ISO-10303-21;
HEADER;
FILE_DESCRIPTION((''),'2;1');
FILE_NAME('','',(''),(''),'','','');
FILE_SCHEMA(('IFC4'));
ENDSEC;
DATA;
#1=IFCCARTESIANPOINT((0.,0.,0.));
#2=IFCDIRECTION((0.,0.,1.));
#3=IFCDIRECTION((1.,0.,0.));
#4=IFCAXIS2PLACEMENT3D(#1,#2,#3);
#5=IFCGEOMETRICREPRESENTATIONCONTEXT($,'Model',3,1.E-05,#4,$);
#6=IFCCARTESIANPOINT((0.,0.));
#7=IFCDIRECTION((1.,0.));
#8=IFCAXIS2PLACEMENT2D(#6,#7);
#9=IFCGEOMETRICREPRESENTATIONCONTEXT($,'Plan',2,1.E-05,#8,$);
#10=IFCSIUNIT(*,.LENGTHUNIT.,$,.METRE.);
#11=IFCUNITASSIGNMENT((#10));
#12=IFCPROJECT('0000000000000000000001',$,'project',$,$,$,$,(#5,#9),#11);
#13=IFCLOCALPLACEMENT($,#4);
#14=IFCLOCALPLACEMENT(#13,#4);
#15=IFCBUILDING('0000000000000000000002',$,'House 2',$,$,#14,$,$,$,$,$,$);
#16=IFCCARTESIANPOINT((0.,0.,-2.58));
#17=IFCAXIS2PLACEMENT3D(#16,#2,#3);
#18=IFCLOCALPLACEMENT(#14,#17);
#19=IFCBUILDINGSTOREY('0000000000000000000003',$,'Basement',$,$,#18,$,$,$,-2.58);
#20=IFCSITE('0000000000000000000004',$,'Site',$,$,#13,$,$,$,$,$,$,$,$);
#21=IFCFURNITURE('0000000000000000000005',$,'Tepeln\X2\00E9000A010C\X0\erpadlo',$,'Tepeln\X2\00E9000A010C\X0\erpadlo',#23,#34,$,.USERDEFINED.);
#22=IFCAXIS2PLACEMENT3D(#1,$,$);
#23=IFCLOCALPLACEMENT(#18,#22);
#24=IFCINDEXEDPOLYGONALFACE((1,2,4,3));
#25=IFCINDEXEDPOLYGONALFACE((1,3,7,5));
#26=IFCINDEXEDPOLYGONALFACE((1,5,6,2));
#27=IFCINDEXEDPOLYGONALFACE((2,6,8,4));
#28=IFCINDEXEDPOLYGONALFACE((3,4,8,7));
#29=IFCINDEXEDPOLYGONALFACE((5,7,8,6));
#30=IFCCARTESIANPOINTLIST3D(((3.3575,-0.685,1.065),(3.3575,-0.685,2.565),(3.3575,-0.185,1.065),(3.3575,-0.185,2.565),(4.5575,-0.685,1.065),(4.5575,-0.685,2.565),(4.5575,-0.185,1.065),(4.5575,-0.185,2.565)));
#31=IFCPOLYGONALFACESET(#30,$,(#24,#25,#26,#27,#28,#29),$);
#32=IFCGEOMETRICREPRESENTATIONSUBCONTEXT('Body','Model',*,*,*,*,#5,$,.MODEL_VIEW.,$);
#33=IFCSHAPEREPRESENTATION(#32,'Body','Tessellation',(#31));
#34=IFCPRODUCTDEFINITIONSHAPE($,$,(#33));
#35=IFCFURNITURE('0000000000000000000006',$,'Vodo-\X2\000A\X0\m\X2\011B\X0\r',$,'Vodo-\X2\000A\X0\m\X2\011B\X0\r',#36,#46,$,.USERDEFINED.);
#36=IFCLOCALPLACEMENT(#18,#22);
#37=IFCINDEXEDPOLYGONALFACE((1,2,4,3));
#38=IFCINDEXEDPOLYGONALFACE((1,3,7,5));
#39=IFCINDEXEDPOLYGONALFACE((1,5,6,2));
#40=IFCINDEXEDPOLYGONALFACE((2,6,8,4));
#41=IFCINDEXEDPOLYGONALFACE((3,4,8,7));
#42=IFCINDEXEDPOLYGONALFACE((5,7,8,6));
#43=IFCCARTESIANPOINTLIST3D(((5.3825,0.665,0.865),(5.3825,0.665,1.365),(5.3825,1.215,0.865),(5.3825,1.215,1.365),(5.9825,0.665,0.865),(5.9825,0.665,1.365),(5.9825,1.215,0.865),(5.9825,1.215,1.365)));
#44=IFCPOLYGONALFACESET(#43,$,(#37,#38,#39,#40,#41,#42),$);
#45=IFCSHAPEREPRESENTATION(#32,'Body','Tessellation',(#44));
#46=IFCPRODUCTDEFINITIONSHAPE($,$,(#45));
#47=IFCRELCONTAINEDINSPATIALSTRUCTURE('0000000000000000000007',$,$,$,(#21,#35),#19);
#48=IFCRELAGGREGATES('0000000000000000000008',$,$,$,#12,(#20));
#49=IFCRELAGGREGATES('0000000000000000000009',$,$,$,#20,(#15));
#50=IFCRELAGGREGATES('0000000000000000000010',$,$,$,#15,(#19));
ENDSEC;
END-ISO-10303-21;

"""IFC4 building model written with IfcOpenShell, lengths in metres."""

from ifc_helpers import new_model, entity, si_unit, frame, origin_with_axes, origin_2d_with_axis, place, context, subcontext, project, spatial, indexed_curve, outline, extrude, shape, element, save


model = new_model("IFC4")

# Units and contexts
model_context = context("Model", 3, precision=1e-05, world=origin_with_axes())
plan_context = context("Plan", 2, precision=1e-05, world=origin_2d_with_axis())
body_context_1 = subcontext(model_context, "Body", "Model", "MODEL_VIEW")
body_context_2 = subcontext(plan_context, "Body", "Plan", "PLAN_VIEW")
ifc_project = project(units=[si_unit("LENGTHUNIT", "METRE")], contexts=[model_context, plan_context])

# Site, building, storey
site_placement = place(None, origin_with_axes())
site = spatial("IfcSite", under=ifc_project, at=site_placement, Name="Site")
building_placement = place(site_placement, origin_with_axes())
building = spatial("IfcBuilding", under=site, at=building_placement, Name="House 2")
storey_placement = place(building_placement, frame((0.0, 0.0, -2.58), z_axis=(0.0, 0.0, 1.0), x_axis=(1.0, 0.0, 0.0)))
storey = spatial("IfcBuildingStorey", under=building, at=storey_placement, Name="Basement", Elevation=-2.58)

# Furniture
furniture_1_placement = place(storey_placement, frame((3.9575, -0.435, 1.065), z_axis=(0.0, 0.0, 1.0), x_axis=(1.0, 0.0, 0.0)))
element("IfcFurniture", 1, at=furniture_1_placement, inside=storey, Name="Tepelné\nČerpadlo", ObjectType="Tepelné\nČerpadlo", PredefinedType="USERDEFINED", shapes=[
    shape(body_context_1, "Body", "SweptSolid", [extrude(outline(indexed_curve([(-0.6, -0.25), (0.6, -0.25), (0.6, 0.25), (-0.6, 0.25)])), None, (0.0, 0.0, 1.0), 1.5)]),
    shape(body_context_2, "Body", "Curve2D", [entity("IfcIndexedPolyCurve", entity("IfcCartesianPointList2D", [[-0.6, -0.25], [0.6, -0.25], [0.6, 0.25], [-0.6, 0.25], [-0.6, -0.25]]), None, False)]),
])
furniture_2_placement = place(storey_placement, frame((5.6825, 0.94, 0.865), z_axis=(0.0, 0.0, 1.0), x_axis=(1.0, 0.0, 0.0)))
element("IfcFurniture", 2, at=furniture_2_placement, inside=storey, Name="Vodo-\nměr", ObjectType="Vodo-\nměr", PredefinedType="USERDEFINED", shapes=[
    shape(body_context_1, "Body", "SweptSolid", [extrude(outline(indexed_curve([(-0.3, -0.275), (0.3, -0.275), (0.3, 0.275), (-0.3, 0.275)])), None, (0.0, 0.0, 1.0), 0.5)]),
    shape(body_context_2, "Body", "Curve2D", [entity("IfcIndexedPolyCurve", entity("IfcCartesianPointList2D", [[-0.3, -0.275], [0.3, -0.275], [0.3, 0.275], [-0.3, 0.275], [-0.3, -0.275]]), None, False)]),
])

save(model, "model.ifc")
